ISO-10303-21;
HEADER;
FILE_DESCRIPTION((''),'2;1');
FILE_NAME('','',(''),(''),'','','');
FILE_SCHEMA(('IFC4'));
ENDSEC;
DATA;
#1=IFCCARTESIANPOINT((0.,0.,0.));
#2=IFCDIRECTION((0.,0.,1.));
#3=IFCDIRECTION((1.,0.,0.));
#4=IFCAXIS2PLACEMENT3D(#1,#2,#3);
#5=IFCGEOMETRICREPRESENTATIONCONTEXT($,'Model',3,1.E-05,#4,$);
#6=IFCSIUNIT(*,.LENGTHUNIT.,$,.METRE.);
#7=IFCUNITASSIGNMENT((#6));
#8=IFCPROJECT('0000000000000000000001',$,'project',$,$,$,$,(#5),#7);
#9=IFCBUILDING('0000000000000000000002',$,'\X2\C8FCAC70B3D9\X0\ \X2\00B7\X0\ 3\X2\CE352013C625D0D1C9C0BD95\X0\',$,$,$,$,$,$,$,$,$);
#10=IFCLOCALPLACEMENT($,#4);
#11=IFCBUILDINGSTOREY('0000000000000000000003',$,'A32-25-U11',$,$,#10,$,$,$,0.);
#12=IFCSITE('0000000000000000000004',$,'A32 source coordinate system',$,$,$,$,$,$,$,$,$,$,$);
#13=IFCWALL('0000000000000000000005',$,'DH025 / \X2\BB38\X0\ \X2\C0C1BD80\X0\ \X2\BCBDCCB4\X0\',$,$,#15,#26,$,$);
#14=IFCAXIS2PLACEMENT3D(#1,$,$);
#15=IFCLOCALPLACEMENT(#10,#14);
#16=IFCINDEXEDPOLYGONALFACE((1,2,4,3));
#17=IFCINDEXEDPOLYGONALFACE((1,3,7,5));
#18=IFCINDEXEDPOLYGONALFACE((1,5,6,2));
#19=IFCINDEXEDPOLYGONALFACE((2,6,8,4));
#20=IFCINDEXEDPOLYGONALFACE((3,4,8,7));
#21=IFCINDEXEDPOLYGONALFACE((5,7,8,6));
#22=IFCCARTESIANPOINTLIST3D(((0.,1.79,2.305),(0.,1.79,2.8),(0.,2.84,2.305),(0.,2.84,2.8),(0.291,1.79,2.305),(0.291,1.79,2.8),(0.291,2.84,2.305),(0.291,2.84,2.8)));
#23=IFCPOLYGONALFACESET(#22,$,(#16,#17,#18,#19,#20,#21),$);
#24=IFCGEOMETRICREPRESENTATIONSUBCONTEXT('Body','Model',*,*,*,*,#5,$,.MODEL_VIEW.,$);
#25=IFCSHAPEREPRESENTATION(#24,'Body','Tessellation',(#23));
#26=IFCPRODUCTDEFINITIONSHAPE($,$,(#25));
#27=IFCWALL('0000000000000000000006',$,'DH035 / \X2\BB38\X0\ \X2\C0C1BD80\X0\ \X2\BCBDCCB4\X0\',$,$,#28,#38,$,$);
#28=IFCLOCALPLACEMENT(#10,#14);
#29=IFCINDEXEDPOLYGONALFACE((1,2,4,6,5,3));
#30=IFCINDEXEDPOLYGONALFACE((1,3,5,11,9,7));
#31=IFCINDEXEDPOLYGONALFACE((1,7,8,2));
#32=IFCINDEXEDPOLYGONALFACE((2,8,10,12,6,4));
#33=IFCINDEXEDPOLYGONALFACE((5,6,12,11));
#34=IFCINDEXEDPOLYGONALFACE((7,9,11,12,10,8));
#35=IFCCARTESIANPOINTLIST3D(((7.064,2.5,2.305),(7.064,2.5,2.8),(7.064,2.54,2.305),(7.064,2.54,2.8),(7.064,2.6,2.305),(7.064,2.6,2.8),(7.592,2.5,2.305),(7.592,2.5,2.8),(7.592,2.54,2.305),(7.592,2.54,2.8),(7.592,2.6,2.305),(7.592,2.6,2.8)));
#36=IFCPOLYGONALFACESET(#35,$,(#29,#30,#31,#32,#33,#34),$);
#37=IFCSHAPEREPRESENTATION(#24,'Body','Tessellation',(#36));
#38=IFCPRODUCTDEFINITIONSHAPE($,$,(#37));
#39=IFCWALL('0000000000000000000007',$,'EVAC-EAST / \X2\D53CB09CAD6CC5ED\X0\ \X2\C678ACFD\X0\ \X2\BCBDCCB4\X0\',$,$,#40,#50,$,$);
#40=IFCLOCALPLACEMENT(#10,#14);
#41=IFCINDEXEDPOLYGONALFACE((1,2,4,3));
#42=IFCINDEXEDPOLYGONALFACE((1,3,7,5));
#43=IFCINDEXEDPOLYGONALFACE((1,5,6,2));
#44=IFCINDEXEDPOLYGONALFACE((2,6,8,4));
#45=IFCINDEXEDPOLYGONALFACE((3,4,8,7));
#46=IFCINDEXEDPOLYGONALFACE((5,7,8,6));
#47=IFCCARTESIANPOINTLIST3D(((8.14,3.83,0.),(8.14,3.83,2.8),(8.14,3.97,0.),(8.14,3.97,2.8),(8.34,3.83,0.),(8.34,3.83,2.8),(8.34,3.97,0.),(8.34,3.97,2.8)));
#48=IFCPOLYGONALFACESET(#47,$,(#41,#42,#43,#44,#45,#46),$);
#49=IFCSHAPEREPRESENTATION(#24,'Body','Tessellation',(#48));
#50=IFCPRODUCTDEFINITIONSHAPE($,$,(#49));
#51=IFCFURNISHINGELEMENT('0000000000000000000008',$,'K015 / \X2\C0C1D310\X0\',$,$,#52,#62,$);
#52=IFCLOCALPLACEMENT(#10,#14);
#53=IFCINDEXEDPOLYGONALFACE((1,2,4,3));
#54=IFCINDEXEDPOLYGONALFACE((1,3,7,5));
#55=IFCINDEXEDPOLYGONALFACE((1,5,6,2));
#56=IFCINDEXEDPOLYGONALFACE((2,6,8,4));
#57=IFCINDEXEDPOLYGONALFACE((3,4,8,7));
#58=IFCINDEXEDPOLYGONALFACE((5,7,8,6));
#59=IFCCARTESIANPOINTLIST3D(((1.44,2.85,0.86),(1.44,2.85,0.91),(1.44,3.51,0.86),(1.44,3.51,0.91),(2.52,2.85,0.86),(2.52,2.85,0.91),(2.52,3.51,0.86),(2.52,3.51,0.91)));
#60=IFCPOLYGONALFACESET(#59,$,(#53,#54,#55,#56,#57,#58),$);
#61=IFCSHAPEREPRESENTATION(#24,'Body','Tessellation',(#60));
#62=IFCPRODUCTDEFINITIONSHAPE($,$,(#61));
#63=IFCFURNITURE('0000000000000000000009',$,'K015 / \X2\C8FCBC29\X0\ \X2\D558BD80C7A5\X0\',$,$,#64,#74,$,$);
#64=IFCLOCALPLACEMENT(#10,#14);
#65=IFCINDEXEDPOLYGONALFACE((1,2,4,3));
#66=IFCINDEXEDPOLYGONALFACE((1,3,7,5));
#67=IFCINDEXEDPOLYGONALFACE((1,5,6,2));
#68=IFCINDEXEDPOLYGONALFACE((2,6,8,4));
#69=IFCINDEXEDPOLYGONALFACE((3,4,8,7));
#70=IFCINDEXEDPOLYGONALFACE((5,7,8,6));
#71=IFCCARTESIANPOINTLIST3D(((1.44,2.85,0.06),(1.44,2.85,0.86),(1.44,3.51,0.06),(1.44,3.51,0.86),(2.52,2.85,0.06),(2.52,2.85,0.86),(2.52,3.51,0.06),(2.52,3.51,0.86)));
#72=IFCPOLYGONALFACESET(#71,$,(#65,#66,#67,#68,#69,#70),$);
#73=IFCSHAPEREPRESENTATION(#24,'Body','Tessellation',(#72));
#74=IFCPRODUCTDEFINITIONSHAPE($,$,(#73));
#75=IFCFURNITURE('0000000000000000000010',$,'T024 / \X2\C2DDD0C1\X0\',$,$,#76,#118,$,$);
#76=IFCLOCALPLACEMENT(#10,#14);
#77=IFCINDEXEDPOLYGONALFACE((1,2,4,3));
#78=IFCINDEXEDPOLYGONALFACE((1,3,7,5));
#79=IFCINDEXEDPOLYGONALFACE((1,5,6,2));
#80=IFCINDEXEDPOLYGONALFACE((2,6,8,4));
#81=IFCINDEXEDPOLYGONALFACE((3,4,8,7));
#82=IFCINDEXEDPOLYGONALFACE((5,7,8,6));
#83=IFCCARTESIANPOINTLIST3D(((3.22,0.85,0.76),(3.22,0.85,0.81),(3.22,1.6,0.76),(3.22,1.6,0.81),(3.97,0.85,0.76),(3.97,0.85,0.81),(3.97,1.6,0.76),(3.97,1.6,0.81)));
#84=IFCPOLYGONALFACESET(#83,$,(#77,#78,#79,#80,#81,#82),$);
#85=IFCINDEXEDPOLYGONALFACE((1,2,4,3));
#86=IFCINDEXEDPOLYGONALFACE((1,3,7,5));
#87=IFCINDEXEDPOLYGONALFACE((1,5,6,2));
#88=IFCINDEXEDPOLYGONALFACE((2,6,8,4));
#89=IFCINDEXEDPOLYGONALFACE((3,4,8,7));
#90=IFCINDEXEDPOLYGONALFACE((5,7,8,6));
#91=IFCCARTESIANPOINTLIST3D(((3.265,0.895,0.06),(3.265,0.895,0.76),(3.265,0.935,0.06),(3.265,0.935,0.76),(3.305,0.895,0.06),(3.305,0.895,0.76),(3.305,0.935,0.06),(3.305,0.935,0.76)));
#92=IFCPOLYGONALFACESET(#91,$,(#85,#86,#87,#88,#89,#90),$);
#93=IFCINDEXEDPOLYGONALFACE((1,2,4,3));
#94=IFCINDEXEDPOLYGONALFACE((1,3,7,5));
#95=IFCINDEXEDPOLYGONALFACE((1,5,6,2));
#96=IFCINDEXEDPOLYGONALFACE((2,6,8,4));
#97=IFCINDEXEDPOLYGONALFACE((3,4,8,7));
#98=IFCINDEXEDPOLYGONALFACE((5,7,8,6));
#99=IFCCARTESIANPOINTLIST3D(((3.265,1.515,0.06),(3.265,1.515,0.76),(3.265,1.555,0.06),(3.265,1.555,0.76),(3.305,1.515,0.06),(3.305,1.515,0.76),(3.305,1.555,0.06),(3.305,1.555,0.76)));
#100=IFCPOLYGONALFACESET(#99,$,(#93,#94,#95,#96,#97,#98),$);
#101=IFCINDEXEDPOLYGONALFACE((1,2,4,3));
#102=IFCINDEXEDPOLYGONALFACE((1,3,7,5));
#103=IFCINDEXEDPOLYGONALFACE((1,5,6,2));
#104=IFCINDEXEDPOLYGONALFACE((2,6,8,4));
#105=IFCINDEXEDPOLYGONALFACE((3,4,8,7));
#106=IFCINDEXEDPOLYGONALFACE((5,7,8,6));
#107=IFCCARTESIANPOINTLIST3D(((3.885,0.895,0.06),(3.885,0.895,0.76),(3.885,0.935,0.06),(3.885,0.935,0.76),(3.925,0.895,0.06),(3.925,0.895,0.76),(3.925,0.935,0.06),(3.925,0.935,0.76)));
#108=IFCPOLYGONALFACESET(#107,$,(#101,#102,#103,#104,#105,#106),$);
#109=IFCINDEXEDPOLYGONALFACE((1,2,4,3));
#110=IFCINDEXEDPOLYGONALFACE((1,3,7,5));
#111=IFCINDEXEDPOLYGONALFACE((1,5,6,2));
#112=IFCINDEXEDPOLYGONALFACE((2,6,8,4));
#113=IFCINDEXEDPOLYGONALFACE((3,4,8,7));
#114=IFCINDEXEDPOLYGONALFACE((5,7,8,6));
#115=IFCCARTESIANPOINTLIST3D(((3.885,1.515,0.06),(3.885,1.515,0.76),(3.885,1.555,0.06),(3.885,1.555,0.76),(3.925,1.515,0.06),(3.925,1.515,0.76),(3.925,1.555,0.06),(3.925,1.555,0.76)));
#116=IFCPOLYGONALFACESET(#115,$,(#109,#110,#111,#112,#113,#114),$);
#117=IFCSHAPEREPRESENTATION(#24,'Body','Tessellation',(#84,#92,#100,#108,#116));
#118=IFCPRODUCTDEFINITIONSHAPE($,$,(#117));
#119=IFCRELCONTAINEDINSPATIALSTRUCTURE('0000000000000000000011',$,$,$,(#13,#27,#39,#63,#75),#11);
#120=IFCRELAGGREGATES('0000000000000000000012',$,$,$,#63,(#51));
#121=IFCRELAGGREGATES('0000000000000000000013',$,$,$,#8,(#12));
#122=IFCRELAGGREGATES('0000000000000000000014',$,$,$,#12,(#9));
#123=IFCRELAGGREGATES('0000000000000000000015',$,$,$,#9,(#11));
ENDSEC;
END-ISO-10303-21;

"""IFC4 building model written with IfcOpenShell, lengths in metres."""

from ifc_helpers import new_model, si_unit, frame, origin, origin_with_axes, place, context, subcontext, project, spatial, polyline, outline, extrude, element, aggregate, save


model = new_model("IFC4")

# Units and contexts
model_context = context("Model", 3, precision=1e-05, world=origin_with_axes())
body_context = subcontext(model_context, "Body", "Model", "MODEL_VIEW")
ifc_project = project(units=[si_unit("LENGTHUNIT", "METRE")], contexts=[model_context])

# Site, building, storey
site = spatial("IfcSite", under=ifc_project, Name="A32 source coordinate system")
building = spatial("IfcBuilding", under=site, Name="주거동 · 3층–옥탑지붕")
storey_placement = place(None, origin_with_axes())
storey = spatial("IfcBuildingStorey", under=building, at=storey_placement, Name="A32-25-U11", Elevation=0.0)

# Walls
wall_1_placement = place(storey_placement, origin_with_axes())
element("IfcWall", 1, at=wall_1_placement, inside=storey, Name="DH025 / 문 상부 벽체", context=body_context, shape_type="SweptSolid", body=[
    extrude(outline(polyline([(0.0, 1.79), (0.0, 2.84), (0.291, 2.84), (0.291, 1.79), (0.0, 1.79)])), frame((0.0, 0.0, 2.305)), (0.0, 0.0, 1.0), 0.495),
])
wall_2_placement = place(storey_placement, origin_with_axes())
element("IfcWall", 2, at=wall_2_placement, inside=storey, Name="DH035 / 문 상부 벽체", context=body_context, shape_type="SweptSolid", body=[
    extrude(outline(polyline([(7.592, 2.6), (7.592, 2.54), (7.592, 2.5), (7.064, 2.5), (7.064, 2.54), (7.064, 2.6), (7.592, 2.6)])), frame((0.0, 0.0, 2.305)), (0.0, 0.0, 1.0), 0.495),
])
wall_3_placement = place(storey_placement, origin_with_axes())
element("IfcWall", 3, at=wall_3_placement, inside=storey, Name="EVAC-EAST / 피난구역 외곽 벽체", context=body_context, shape_type="SweptSolid", body=[
    extrude(outline(polyline([(8.34, 3.83), (8.14, 3.83), (8.14, 3.97), (8.34, 3.97), (8.34, 3.83)])), origin(), (0.0, 0.0, 1.0), 2.8),
])

# Furnishing element
furniture_1_placement = place(storey_placement, origin_with_axes())
furnishing_1_placement = place(furniture_1_placement, origin_with_axes())
furnishing_1 = element("IfcFurnishingElement", 4, at=furnishing_1_placement, Name="K015 / 상판", context=body_context, shape_type="SweptSolid", body=[
    extrude(outline(polyline([(2.52, 2.85), (1.44, 2.85), (1.44, 3.51), (2.52, 3.51), (2.52, 2.85)])), frame((0.0, 0.0, 0.86)), (0.0, 0.0, 1.0), 0.05),
])

# Furniture
furniture_1 = element("IfcFurniture", 5, at=furniture_1_placement, inside=storey, Name="K015 / 주방 하부장", context=body_context, shape_type="SweptSolid", body=[
    extrude(outline(polyline([(2.52, 3.51), (2.52, 2.85), (1.44, 2.85), (1.44, 3.51), (2.52, 3.51)])), frame((0.0, 0.0, 0.06)), (0.0, 0.0, 1.0), 0.8),
])
aggregate(furniture_1, [furnishing_1])
furniture_2_placement = place(storey_placement, origin_with_axes())
element("IfcFurniture", 6, at=furniture_2_placement, inside=storey, Name="T024 / 식탁", context=body_context, shape_type="SweptSolid", body=[
    extrude(outline(polyline([(3.22, 0.85), (3.22, 1.6), (3.97, 1.6), (3.97, 0.85), (3.22, 0.85)])), frame((0.0, 0.0, 0.76)), (0.0, 0.0, 1.0), 0.05),
    extrude(outline(polyline([(3.265, 0.895), (3.265, 0.935), (3.305, 0.935), (3.305, 0.895), (3.265, 0.895)])), frame((0.0, 0.0, 0.06)), (0.0, 0.0, 1.0), 0.7),
    extrude(outline(polyline([(3.265, 1.515), (3.265, 1.555), (3.305, 1.555), (3.305, 1.515), (3.265, 1.515)])), frame((0.0, 0.0, 0.06)), (0.0, 0.0, 1.0), 0.7),
    extrude(outline(polyline([(3.885, 0.895), (3.885, 0.935), (3.925, 0.935), (3.925, 0.895), (3.885, 0.895)])), frame((0.0, 0.0, 0.06)), (0.0, 0.0, 1.0), 0.7),
    extrude(outline(polyline([(3.885, 1.515), (3.885, 1.555), (3.925, 1.555), (3.925, 1.515), (3.885, 1.515)])), frame((0.0, 0.0, 0.06)), (0.0, 0.0, 1.0), 0.7),
])

save(model, "model.ifc")
